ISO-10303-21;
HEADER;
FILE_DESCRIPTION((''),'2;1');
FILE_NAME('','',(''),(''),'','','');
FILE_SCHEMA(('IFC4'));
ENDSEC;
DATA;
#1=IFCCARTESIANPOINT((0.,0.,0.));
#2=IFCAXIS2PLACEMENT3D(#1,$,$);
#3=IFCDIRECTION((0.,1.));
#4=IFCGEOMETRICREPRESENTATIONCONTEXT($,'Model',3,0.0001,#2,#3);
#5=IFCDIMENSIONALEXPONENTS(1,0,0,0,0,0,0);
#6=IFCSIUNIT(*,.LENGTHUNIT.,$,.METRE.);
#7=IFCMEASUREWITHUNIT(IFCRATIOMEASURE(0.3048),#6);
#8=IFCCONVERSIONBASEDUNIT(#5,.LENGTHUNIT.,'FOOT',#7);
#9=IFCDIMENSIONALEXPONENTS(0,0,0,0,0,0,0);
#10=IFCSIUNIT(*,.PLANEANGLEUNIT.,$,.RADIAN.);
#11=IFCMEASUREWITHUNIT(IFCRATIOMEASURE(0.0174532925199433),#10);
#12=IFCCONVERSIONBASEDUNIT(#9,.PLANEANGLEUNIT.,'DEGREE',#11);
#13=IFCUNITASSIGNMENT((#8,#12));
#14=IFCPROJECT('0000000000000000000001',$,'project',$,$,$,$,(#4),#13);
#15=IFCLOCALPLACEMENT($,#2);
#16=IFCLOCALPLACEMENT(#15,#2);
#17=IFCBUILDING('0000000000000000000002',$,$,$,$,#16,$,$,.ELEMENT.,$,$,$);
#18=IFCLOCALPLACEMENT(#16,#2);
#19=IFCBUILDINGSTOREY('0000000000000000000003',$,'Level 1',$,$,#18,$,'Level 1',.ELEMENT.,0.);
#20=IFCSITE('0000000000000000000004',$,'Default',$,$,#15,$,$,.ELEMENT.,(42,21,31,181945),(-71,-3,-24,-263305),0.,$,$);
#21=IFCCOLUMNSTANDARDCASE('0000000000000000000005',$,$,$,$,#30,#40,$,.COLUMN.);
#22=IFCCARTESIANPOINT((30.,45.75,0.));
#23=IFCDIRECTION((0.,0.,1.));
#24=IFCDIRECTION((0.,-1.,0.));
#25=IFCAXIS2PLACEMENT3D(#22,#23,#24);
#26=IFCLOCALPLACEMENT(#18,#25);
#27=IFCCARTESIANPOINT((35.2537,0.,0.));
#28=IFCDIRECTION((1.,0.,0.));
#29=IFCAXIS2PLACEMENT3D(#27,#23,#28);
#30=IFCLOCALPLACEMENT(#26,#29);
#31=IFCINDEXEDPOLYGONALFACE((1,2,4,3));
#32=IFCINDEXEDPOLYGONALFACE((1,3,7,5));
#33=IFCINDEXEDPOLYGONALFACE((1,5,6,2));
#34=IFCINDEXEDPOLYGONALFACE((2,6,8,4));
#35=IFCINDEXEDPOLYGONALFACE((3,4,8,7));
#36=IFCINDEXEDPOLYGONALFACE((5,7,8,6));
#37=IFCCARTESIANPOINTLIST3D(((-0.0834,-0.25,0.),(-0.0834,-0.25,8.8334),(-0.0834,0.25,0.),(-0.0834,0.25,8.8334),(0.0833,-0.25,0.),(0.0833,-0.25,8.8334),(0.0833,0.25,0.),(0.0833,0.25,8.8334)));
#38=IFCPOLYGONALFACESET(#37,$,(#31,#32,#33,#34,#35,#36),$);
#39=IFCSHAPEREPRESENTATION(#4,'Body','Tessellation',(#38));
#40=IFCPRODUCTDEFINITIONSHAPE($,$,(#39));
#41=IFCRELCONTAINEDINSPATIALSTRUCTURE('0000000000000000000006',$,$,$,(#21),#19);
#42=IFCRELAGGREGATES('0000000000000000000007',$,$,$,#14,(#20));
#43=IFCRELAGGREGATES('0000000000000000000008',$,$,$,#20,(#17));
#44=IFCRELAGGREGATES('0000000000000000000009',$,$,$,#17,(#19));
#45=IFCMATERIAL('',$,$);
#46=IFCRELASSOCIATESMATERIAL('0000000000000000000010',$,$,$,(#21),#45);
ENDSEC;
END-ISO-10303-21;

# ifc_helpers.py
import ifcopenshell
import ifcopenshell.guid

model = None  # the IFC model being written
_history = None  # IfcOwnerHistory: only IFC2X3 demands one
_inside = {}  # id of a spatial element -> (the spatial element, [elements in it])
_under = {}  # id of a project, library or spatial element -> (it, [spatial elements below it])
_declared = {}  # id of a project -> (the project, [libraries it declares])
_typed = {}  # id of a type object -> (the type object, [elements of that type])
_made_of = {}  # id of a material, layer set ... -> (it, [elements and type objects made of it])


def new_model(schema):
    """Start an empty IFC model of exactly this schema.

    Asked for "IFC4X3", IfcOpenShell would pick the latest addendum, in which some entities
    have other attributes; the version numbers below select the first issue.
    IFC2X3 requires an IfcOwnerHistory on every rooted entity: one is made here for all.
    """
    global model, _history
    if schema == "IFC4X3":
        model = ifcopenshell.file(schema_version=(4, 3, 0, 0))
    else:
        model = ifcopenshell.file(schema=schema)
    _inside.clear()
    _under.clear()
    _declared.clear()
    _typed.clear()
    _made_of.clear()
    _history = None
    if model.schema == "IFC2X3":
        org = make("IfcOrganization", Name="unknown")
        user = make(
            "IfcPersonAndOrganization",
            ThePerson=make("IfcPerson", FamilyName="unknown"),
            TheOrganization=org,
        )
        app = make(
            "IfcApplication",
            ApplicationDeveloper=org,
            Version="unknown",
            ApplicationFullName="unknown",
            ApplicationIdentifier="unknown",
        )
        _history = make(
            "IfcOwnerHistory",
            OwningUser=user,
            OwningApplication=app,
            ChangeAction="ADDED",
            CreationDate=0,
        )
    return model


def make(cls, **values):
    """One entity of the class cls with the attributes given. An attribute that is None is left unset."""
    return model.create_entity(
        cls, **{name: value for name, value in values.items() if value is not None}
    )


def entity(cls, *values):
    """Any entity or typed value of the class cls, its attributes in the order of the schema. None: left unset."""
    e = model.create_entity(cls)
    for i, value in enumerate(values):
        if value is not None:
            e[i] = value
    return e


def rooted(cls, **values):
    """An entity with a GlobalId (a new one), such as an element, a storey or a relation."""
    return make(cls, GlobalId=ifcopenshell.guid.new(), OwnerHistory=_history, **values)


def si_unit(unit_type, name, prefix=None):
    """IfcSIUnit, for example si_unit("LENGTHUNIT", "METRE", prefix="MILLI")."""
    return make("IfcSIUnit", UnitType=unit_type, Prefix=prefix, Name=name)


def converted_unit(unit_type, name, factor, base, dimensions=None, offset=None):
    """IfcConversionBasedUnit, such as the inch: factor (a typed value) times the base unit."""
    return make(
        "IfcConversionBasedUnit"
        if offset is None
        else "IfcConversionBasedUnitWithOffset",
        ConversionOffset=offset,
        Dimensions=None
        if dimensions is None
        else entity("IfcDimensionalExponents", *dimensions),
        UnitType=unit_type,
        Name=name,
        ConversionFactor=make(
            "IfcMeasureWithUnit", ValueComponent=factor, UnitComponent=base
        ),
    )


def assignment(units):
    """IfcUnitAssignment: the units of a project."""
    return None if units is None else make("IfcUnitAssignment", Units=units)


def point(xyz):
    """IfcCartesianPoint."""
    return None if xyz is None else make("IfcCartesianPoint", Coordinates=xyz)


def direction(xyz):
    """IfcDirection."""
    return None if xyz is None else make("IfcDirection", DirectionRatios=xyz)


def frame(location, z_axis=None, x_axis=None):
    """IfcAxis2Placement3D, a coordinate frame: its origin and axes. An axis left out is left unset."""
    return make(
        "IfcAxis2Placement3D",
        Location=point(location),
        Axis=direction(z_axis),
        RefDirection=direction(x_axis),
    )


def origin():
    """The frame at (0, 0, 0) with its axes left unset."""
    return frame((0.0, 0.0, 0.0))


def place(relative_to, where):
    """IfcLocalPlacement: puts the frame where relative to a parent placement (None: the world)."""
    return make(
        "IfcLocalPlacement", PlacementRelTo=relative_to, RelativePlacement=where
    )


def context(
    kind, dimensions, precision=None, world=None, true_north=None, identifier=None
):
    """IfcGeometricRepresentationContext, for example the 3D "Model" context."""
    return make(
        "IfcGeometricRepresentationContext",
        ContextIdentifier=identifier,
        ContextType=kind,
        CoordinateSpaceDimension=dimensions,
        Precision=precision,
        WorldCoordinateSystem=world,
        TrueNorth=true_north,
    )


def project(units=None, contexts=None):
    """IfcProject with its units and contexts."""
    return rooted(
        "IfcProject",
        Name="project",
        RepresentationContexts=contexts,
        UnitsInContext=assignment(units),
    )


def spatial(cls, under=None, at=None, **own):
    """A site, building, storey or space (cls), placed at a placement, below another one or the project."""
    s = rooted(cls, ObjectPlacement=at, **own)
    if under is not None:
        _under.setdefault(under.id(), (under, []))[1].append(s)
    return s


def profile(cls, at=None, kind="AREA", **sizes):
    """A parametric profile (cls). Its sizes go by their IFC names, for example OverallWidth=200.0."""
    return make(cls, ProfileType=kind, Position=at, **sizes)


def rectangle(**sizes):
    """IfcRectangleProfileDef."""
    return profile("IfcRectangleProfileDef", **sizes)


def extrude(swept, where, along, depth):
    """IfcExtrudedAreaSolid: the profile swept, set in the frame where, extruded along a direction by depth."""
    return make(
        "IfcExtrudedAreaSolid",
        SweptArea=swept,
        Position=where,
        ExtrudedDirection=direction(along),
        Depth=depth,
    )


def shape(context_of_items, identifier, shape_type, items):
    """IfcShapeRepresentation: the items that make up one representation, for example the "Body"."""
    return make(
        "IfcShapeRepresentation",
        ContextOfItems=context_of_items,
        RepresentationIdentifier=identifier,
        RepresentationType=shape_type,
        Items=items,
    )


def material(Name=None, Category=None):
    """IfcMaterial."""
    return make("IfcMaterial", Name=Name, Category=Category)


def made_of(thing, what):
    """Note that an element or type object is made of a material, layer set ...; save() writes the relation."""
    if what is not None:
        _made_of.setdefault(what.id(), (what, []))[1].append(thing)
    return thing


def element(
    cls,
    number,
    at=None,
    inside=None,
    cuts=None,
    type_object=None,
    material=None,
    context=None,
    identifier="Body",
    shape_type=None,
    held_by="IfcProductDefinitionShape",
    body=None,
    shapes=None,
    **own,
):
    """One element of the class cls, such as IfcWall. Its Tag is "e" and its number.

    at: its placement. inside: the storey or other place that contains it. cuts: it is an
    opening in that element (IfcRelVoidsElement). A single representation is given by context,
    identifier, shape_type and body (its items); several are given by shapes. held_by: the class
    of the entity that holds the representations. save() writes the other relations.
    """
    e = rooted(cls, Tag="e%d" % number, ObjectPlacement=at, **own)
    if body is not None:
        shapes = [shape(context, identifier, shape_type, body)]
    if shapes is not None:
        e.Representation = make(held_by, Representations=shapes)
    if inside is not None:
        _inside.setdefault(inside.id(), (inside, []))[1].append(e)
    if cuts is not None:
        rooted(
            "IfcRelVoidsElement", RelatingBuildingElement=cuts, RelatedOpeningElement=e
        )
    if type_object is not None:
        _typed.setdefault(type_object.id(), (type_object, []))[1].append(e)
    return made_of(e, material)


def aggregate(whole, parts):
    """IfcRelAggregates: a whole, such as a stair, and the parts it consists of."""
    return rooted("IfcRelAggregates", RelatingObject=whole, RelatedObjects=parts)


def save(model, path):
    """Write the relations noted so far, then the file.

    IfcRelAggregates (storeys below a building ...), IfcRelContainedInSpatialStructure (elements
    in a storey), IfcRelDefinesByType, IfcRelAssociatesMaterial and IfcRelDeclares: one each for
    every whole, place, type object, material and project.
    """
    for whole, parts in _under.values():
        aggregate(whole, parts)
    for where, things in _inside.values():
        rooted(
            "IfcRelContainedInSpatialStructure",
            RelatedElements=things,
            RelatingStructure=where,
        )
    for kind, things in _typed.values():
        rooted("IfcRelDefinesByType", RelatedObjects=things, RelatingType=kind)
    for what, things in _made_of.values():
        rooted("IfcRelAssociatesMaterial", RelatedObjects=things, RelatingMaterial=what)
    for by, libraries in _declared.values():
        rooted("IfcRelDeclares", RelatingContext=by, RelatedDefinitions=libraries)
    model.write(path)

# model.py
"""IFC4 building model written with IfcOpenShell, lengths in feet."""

from ifc_helpers import new_model, entity, si_unit, converted_unit, direction, frame, origin, place, context, project, spatial, rectangle, extrude, material, element, save


model = new_model("IFC4")

# Units and contexts
model_context = context("Model", 3, precision=0.0001, world=origin(), true_north=direction((0.0, 1.0)))
ifc_project = project(units=[converted_unit("LENGTHUNIT", "FOOT", entity("IfcRatioMeasure", 0.3048), si_unit("LENGTHUNIT", "METRE"), dimensions=[1, 0, 0, 0, 0, 0, 0]), converted_unit("PLANEANGLEUNIT", "DEGREE", entity("IfcRatioMeasure", 0.0174532925199433), si_unit("PLANEANGLEUNIT", "RADIAN"), dimensions=[0, 0, 0, 0, 0, 0, 0])], contexts=[model_context])

# Site, building, storey
site_placement = place(None, origin())
site = spatial("IfcSite", under=ifc_project, at=site_placement, Name="Default", CompositionType="ELEMENT", RefLatitude=(42, 21, 31, 181945), RefLongitude=(-71, -3, -24, -263305), RefElevation=0.0)
building_placement = place(site_placement, origin())
building = spatial("IfcBuilding", under=site, at=building_placement, CompositionType="ELEMENT")
storey_placement = place(building_placement, origin())
storey = spatial("IfcBuildingStorey", under=building, at=storey_placement, Name="Level 1", LongName="Level 1", CompositionType="ELEMENT", Elevation=0.0)

# Column
ifc_material_1 = material(Name="")
placement_1 = place(storey_placement, frame((30.0, 45.75, 0.0), z_axis=(0.0, 0.0, 1.0), x_axis=(0.0, -1.0, 0.0)))
for number, where, z_axis, x_axis in (
    (1, (35.2537, 0.0, 0.0), (0.0, 0.0, 1.0), (1.0, 0.0, 0.0)),
):
    element("IfcColumnStandardCase", number, at=place(placement_1, frame(where, z_axis=z_axis, x_axis=x_axis)), inside=storey, material=ifc_material_1, PredefinedType="COLUMN", context=model_context, shape_type="SweptSolid", body=[
        extrude(rectangle(XDim=0.1667, YDim=0.5), origin(), (0.0, 0.0, 1.0), 8.8334),
    ])

save(model, "model.ifc")
